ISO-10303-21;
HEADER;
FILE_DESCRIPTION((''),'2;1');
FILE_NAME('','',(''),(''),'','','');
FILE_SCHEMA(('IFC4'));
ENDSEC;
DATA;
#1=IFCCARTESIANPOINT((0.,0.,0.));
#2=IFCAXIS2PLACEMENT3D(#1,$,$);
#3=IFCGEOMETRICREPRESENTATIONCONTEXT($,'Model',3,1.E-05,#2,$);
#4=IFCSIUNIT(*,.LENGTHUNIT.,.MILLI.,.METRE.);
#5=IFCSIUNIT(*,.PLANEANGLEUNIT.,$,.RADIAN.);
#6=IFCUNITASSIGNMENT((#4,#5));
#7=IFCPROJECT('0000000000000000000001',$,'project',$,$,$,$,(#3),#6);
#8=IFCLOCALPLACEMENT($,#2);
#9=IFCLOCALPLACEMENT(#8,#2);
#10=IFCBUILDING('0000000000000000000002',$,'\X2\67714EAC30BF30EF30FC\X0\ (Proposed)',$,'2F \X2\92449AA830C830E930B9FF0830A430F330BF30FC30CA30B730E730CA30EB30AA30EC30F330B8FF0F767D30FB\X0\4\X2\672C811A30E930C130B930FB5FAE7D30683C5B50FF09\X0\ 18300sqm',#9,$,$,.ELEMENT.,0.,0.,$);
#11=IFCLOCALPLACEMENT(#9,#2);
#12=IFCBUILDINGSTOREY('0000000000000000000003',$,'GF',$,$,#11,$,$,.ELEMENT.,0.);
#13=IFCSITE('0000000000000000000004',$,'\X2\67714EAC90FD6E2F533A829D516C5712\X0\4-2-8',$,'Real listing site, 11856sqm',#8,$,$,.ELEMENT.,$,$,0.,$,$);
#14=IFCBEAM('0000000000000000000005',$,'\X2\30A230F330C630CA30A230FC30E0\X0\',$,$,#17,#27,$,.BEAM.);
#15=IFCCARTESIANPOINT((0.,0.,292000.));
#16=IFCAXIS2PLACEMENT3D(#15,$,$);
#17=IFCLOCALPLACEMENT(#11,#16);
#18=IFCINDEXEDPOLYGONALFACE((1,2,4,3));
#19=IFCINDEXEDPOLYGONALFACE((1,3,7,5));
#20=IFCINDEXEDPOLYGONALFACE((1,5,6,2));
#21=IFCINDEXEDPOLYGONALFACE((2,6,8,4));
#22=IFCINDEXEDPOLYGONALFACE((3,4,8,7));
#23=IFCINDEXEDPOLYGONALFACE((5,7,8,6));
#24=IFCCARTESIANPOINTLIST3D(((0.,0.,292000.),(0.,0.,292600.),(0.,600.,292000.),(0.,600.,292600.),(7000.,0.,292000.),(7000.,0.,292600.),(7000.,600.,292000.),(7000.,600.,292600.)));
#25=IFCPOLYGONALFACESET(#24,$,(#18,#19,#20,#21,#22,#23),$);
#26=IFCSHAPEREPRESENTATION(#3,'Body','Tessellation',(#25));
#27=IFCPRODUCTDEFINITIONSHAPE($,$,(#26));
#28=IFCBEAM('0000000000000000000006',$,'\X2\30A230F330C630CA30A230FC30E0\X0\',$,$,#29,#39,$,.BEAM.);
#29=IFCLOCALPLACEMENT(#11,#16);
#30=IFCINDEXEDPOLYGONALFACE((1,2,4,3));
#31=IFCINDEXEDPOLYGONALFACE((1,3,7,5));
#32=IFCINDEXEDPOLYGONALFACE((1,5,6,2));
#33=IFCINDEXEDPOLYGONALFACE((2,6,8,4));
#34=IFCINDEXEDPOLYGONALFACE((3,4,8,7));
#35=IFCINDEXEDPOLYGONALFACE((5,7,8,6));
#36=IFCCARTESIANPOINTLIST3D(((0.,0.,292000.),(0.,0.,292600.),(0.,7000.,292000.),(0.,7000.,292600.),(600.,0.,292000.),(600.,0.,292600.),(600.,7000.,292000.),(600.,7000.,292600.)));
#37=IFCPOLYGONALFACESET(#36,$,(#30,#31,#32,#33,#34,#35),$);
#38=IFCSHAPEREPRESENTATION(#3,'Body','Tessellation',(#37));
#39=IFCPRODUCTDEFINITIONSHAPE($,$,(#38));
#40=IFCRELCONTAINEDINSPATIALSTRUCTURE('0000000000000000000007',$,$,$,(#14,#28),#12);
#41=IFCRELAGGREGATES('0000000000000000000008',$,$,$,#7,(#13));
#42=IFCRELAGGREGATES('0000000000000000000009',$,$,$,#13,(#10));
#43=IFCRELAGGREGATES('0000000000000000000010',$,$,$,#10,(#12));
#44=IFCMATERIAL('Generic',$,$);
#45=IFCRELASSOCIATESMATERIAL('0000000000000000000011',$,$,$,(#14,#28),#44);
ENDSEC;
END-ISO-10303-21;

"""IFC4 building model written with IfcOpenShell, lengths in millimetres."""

from ifc_helpers import new_model, si_unit, frame, frame_2d, origin, place, context, project, spatial, rectangle, extrude, material, element, save


model = new_model("IFC4")

# Units and contexts
model_context = context("Model", 3, precision=1e-05, world=origin())
ifc_project = project(units=[si_unit("LENGTHUNIT", "METRE", prefix="MILLI"), si_unit("PLANEANGLEUNIT", "RADIAN")], contexts=[model_context])

# Site, building, storey
site_placement = place(None, origin())
site = spatial("IfcSite", under=ifc_project, at=site_placement, Name="東京都港区芝公園4-2-8", ObjectType="Real listing site, 11856sqm", CompositionType="ELEMENT", RefElevation=0.0)
building_placement = place(site_placement, origin())
building = spatial("IfcBuilding", under=site, at=building_placement, Name="東京タワー (Proposed)", ObjectType="2F 鉄骨トラス（インターナショナルオレンジ／白・4本脚ラチス・微細格子） 18300sqm", CompositionType="ELEMENT", ElevationOfRefHeight=0.0, ElevationOfTerrain=0.0)
storey_placement = place(building_placement, origin())
storey = spatial("IfcBuildingStorey", under=building, at=storey_placement, Name="GF", CompositionType="ELEMENT", Elevation=0.0)

# Shared definitions
ifc_material = material(Name="Generic")

# Beams
beam_1_placement = place(storey_placement, frame((0.0, 0.0, 292000.0)))
element("IfcBeam", 1, at=beam_1_placement, inside=storey, material=ifc_material, Name="アンテナアーム", PredefinedType="BEAM", context=model_context, shape_type="SweptSolid", body=[
    extrude(rectangle(XDim=7000.0, YDim=600.0, at=frame_2d((3500.0, 300.0))), frame((0.0, 0.0, 292000.0)), (0.0, 0.0, 1.0), 600.0),
])
beam_2_placement = place(storey_placement, frame((0.0, 0.0, 292000.0)))
element("IfcBeam", 2, at=beam_2_placement, inside=storey, material=ifc_material, Name="アンテナアーム", PredefinedType="BEAM", context=model_context, shape_type="SweptSolid", body=[
    extrude(rectangle(XDim=600.0, YDim=7000.0, at=frame_2d((300.0, 3500.0))), frame((0.0, 0.0, 292000.0)), (0.0, 0.0, 1.0), 600.0),
])

save(model, "model.ifc")
